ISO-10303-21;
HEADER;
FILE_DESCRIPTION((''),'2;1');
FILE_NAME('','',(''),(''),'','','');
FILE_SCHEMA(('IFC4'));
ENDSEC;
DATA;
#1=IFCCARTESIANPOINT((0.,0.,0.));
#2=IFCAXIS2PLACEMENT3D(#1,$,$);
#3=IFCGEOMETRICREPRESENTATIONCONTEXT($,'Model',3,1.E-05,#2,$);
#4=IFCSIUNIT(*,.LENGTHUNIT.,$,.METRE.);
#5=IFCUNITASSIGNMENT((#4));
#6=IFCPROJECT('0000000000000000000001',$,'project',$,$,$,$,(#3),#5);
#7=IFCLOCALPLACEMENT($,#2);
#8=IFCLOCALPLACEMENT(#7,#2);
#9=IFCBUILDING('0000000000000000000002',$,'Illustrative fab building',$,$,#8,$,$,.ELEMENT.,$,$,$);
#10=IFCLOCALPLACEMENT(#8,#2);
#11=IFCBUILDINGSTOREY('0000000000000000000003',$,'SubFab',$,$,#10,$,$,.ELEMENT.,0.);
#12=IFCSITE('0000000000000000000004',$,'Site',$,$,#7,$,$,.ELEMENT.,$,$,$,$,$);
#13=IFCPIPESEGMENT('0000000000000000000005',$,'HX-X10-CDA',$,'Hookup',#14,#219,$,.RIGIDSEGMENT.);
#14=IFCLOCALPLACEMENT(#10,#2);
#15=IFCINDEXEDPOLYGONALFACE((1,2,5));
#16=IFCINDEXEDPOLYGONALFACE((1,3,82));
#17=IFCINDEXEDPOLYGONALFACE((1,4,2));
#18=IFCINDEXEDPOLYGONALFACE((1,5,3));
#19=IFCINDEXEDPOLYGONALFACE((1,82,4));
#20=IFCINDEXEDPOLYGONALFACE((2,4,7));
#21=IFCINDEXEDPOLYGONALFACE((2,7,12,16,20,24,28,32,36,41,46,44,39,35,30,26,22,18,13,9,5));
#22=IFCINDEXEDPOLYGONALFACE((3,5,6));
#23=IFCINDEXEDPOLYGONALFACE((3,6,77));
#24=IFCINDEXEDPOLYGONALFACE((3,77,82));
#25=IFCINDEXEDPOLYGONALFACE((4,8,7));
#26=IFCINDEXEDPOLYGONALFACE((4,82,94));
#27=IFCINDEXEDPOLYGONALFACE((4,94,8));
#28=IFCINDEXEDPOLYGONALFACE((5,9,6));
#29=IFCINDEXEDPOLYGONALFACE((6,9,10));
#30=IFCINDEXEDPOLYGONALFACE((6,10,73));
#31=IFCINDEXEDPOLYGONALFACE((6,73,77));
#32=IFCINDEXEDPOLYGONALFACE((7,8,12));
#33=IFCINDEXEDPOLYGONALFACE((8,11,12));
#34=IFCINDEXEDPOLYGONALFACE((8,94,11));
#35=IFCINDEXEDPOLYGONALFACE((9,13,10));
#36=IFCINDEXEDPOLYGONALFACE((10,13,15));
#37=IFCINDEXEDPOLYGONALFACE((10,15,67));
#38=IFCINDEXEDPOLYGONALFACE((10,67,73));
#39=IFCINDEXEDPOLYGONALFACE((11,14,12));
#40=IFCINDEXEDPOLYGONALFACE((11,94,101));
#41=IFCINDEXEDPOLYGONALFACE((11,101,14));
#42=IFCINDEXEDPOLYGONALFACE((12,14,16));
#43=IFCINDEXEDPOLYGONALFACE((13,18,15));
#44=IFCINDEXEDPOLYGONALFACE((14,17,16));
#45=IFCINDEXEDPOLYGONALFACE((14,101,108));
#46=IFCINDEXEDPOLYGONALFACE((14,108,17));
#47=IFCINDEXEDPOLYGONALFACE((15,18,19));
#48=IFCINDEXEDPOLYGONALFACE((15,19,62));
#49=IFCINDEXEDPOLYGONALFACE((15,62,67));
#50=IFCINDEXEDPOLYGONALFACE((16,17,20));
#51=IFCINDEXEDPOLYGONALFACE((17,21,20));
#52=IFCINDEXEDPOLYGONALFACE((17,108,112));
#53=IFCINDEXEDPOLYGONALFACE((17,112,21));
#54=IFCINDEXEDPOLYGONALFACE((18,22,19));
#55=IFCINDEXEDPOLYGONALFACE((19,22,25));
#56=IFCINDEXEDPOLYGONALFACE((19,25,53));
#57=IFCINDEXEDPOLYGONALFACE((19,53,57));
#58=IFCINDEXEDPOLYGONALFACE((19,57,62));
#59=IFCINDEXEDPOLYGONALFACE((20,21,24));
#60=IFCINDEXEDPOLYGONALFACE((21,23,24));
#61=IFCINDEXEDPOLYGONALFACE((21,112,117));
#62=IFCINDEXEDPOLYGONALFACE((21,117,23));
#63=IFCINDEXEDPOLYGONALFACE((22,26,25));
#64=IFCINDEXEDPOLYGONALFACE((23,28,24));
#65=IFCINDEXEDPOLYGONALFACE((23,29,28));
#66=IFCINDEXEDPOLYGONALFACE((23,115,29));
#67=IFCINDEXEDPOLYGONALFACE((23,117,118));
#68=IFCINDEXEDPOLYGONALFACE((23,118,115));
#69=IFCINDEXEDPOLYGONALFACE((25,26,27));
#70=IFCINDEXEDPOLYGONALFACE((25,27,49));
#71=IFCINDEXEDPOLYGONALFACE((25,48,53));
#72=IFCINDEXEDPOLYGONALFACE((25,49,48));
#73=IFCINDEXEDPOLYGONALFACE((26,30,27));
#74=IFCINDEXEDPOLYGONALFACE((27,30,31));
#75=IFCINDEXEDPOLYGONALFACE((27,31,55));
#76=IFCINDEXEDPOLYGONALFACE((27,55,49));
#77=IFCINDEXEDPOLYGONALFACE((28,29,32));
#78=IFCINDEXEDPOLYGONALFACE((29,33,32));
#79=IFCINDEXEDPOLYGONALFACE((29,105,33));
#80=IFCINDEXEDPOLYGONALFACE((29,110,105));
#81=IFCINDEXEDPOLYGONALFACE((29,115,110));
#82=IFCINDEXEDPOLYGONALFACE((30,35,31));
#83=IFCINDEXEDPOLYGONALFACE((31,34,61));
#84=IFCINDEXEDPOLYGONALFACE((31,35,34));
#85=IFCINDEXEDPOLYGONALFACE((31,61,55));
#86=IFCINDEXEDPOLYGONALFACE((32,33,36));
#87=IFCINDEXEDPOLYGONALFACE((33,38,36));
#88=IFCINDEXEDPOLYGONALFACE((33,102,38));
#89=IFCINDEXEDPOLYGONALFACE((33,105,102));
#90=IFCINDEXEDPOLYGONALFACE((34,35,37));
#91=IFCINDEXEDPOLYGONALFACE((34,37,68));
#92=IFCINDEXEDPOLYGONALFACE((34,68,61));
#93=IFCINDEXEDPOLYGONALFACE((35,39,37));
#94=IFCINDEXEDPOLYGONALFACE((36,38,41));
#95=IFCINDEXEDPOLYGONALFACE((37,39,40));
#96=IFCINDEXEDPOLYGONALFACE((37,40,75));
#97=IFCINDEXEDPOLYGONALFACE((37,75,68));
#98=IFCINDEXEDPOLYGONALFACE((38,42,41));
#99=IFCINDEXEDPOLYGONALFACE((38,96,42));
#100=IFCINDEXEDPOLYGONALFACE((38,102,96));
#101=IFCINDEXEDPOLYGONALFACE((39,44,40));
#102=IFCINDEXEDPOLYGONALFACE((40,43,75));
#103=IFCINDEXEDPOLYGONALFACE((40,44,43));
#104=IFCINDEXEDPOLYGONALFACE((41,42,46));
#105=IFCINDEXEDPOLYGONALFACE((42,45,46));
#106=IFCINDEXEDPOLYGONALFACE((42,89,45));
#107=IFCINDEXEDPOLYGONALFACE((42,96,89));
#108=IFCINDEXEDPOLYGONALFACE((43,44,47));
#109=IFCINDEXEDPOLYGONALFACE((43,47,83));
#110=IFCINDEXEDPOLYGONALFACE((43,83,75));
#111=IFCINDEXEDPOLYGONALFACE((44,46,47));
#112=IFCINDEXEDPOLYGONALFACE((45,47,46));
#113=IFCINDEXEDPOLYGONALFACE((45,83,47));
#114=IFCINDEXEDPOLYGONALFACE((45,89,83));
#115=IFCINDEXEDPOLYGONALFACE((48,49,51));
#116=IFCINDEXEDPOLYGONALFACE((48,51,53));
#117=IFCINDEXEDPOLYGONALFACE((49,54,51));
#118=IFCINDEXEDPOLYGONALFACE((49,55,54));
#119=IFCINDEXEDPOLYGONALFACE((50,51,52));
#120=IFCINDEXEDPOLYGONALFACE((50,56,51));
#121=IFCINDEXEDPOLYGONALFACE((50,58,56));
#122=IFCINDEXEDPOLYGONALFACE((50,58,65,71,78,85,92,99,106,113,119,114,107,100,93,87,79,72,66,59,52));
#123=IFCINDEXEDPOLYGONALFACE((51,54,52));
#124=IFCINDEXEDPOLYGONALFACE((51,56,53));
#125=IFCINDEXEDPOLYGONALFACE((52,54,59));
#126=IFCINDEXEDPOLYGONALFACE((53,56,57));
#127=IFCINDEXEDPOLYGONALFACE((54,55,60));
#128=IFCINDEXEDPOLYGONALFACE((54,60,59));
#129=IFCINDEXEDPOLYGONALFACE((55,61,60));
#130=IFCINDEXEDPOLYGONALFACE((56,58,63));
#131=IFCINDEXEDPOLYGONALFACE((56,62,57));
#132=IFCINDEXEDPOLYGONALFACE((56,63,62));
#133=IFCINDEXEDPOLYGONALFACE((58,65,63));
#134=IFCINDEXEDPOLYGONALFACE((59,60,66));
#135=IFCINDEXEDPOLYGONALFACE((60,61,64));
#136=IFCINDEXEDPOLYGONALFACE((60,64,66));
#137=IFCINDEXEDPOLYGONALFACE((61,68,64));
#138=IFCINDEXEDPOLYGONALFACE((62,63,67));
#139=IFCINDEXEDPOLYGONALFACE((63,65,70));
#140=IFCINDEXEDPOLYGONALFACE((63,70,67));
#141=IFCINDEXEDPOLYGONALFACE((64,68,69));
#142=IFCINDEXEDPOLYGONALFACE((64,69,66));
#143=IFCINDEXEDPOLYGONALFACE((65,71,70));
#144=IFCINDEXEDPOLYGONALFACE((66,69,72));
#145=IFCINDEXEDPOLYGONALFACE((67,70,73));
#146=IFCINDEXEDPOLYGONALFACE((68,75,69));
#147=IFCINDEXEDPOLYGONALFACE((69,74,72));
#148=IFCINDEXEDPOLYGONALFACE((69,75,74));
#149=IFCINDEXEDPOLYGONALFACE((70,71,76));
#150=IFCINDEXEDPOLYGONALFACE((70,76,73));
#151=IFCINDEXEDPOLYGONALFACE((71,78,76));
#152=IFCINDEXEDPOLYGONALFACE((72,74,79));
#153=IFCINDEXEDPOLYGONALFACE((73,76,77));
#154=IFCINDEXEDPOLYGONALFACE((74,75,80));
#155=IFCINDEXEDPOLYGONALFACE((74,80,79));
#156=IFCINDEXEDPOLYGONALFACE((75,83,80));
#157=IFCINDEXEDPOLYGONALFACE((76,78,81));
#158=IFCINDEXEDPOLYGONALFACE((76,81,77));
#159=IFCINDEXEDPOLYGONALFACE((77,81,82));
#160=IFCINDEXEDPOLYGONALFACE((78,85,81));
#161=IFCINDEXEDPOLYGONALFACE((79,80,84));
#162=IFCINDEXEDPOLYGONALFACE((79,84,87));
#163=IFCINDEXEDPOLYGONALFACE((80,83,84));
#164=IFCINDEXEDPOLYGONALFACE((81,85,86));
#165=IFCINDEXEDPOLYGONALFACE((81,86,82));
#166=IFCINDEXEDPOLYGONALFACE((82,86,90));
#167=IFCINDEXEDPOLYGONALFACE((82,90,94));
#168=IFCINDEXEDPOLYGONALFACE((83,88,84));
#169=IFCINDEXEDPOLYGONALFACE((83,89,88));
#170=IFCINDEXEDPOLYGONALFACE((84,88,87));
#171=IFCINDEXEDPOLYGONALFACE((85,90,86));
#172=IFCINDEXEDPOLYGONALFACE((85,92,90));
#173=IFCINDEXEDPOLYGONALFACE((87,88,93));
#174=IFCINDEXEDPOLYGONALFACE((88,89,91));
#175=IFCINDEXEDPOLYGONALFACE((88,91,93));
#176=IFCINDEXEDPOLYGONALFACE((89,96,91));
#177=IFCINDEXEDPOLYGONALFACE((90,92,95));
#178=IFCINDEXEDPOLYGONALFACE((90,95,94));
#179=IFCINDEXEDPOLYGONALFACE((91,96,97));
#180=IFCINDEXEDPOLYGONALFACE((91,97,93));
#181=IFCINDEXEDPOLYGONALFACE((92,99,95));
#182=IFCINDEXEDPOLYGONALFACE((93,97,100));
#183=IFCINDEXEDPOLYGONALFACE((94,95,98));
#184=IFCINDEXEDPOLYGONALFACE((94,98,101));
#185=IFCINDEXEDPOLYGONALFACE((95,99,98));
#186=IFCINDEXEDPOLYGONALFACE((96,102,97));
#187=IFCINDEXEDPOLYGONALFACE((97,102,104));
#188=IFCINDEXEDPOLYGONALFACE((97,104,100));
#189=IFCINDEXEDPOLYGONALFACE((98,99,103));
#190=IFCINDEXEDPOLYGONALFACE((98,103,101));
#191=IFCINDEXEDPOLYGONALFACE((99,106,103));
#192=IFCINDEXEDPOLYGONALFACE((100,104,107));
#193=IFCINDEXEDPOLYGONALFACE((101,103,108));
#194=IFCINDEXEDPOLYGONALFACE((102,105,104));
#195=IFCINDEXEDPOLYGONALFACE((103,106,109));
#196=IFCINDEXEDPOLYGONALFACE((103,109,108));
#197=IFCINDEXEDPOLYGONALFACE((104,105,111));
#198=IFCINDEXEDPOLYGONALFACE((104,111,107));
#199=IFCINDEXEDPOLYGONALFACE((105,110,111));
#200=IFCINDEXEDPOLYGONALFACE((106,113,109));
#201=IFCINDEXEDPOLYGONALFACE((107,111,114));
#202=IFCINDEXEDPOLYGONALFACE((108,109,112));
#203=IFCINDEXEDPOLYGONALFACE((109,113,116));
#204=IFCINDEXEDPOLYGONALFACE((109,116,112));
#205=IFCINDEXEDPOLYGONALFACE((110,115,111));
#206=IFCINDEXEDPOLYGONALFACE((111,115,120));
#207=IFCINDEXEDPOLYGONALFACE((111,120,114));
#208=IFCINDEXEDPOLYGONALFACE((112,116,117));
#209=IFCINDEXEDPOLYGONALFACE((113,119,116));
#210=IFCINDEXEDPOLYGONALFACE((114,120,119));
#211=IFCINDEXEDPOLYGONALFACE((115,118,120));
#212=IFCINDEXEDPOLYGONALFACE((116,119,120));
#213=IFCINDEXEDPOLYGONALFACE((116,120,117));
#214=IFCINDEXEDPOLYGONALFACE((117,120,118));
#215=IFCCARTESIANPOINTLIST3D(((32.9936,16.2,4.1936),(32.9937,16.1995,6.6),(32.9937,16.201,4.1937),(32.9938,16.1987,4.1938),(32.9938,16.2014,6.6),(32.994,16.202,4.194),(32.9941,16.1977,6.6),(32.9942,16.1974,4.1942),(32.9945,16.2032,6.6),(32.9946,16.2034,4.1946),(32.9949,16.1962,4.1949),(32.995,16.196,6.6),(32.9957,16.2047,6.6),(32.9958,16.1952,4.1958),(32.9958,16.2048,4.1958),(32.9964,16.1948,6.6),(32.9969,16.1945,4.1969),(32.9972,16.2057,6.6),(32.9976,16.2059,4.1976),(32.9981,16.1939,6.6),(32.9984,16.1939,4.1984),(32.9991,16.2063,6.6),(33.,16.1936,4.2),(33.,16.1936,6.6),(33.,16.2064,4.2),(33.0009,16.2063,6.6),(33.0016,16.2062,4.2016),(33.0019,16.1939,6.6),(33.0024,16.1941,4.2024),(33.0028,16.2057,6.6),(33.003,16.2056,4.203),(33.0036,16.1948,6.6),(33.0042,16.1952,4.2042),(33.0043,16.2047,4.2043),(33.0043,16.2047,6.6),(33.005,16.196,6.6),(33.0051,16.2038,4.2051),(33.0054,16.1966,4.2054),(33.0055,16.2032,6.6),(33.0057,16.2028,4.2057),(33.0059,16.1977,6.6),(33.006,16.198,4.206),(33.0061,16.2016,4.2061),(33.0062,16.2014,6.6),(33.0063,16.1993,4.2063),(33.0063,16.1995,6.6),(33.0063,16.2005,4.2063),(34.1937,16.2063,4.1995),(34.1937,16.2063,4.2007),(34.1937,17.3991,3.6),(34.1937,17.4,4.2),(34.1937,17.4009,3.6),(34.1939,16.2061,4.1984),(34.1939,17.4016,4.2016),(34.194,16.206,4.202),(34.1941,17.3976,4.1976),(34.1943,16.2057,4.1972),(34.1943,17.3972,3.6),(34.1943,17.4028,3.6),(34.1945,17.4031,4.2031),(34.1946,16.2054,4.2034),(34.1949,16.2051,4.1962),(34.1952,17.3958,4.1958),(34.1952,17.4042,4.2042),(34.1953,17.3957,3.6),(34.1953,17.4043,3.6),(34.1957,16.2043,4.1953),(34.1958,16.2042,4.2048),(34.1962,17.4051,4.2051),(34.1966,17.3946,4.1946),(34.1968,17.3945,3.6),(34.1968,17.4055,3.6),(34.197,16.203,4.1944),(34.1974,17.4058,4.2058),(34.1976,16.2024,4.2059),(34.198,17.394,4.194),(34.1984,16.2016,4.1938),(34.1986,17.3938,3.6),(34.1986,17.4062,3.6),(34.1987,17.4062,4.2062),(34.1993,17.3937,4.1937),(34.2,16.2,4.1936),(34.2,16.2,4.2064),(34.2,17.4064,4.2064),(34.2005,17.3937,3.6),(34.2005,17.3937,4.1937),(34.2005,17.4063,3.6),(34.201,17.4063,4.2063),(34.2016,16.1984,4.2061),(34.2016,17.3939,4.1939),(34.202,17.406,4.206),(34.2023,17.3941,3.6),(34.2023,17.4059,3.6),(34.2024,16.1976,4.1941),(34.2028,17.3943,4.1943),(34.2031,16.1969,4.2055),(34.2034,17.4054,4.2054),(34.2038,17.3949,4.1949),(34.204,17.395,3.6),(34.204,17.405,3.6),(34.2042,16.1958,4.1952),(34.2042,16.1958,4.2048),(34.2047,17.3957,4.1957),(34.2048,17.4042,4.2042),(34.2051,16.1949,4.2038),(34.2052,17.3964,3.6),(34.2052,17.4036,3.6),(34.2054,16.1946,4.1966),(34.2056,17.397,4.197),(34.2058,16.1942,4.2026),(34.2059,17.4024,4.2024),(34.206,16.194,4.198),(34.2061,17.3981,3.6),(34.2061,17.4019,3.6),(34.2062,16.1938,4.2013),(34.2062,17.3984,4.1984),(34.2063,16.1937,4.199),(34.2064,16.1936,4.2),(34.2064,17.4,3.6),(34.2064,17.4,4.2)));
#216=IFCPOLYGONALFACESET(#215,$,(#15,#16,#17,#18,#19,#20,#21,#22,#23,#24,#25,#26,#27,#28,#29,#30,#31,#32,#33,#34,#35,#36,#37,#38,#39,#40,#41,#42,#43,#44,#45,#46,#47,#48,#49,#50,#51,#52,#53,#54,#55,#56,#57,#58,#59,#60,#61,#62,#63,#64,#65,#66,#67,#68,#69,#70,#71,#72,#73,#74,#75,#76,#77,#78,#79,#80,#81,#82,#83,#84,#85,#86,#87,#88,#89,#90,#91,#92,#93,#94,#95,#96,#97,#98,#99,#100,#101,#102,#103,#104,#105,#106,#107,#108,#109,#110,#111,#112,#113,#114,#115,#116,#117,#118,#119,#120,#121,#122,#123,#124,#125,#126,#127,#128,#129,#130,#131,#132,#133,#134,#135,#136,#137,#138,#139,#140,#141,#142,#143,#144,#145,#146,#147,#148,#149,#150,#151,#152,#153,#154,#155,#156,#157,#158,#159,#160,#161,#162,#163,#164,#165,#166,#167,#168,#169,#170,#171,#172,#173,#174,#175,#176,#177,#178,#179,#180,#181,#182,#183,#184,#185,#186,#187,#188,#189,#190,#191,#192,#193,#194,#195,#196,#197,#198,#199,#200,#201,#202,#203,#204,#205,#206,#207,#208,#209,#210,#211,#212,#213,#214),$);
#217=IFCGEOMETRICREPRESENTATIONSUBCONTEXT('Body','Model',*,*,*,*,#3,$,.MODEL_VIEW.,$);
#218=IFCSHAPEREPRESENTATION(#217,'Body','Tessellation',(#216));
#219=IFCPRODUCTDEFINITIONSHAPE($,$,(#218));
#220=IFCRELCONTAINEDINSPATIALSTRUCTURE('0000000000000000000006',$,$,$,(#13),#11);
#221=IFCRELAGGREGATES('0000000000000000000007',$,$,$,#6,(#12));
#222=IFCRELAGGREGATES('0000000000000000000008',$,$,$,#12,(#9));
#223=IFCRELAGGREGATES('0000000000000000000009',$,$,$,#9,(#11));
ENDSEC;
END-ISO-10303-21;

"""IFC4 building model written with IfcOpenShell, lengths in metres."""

from ifc_helpers import new_model, entity, si_unit, origin, place, context, subcontext, project, spatial, element, save


model = new_model("IFC4")

# Units and contexts
model_context = context("Model", 3, precision=1e-05, world=origin())
body_context = subcontext(model_context, "Body", "Model", "MODEL_VIEW")
ifc_project = project(units=[si_unit("LENGTHUNIT", "METRE")], contexts=[model_context])

# Site, building, storey
site_placement = place(None, origin())
site = spatial("IfcSite", under=ifc_project, at=site_placement, Name="Site", CompositionType="ELEMENT")
building_placement = place(site_placement, origin())
building = spatial("IfcBuilding", under=site, at=building_placement, Name="Illustrative fab building", CompositionType="ELEMENT")
storey_placement = place(building_placement, origin())
storey = spatial("IfcBuildingStorey", under=building, at=storey_placement, Name="SubFab", CompositionType="ELEMENT", Elevation=0.0)

# Pipe segment
pipe_segment_1_placement = place(storey_placement, origin())
element("IfcPipeSegment", 1, at=pipe_segment_1_placement, inside=storey, Name="HX-X10-CDA", ObjectType="Hookup", PredefinedType="RIGIDSEGMENT", context=body_context, shape_type="AdvancedSweptSolid", body=[
    entity("IfcSweptDiskSolid", entity("IfcPolyline", [entity("IfcCartesianPoint", [34.2, 17.4, 3.6]), entity("IfcCartesianPoint", [34.2, 17.4, 4.2]), entity("IfcCartesianPoint", [34.2, 16.2, 4.2]), entity("IfcCartesianPoint", [33.0, 16.2, 4.2]), entity("IfcCartesianPoint", [33.0, 16.2, 6.6])]), 0.0063),
])

save(model, "model.ifc")
